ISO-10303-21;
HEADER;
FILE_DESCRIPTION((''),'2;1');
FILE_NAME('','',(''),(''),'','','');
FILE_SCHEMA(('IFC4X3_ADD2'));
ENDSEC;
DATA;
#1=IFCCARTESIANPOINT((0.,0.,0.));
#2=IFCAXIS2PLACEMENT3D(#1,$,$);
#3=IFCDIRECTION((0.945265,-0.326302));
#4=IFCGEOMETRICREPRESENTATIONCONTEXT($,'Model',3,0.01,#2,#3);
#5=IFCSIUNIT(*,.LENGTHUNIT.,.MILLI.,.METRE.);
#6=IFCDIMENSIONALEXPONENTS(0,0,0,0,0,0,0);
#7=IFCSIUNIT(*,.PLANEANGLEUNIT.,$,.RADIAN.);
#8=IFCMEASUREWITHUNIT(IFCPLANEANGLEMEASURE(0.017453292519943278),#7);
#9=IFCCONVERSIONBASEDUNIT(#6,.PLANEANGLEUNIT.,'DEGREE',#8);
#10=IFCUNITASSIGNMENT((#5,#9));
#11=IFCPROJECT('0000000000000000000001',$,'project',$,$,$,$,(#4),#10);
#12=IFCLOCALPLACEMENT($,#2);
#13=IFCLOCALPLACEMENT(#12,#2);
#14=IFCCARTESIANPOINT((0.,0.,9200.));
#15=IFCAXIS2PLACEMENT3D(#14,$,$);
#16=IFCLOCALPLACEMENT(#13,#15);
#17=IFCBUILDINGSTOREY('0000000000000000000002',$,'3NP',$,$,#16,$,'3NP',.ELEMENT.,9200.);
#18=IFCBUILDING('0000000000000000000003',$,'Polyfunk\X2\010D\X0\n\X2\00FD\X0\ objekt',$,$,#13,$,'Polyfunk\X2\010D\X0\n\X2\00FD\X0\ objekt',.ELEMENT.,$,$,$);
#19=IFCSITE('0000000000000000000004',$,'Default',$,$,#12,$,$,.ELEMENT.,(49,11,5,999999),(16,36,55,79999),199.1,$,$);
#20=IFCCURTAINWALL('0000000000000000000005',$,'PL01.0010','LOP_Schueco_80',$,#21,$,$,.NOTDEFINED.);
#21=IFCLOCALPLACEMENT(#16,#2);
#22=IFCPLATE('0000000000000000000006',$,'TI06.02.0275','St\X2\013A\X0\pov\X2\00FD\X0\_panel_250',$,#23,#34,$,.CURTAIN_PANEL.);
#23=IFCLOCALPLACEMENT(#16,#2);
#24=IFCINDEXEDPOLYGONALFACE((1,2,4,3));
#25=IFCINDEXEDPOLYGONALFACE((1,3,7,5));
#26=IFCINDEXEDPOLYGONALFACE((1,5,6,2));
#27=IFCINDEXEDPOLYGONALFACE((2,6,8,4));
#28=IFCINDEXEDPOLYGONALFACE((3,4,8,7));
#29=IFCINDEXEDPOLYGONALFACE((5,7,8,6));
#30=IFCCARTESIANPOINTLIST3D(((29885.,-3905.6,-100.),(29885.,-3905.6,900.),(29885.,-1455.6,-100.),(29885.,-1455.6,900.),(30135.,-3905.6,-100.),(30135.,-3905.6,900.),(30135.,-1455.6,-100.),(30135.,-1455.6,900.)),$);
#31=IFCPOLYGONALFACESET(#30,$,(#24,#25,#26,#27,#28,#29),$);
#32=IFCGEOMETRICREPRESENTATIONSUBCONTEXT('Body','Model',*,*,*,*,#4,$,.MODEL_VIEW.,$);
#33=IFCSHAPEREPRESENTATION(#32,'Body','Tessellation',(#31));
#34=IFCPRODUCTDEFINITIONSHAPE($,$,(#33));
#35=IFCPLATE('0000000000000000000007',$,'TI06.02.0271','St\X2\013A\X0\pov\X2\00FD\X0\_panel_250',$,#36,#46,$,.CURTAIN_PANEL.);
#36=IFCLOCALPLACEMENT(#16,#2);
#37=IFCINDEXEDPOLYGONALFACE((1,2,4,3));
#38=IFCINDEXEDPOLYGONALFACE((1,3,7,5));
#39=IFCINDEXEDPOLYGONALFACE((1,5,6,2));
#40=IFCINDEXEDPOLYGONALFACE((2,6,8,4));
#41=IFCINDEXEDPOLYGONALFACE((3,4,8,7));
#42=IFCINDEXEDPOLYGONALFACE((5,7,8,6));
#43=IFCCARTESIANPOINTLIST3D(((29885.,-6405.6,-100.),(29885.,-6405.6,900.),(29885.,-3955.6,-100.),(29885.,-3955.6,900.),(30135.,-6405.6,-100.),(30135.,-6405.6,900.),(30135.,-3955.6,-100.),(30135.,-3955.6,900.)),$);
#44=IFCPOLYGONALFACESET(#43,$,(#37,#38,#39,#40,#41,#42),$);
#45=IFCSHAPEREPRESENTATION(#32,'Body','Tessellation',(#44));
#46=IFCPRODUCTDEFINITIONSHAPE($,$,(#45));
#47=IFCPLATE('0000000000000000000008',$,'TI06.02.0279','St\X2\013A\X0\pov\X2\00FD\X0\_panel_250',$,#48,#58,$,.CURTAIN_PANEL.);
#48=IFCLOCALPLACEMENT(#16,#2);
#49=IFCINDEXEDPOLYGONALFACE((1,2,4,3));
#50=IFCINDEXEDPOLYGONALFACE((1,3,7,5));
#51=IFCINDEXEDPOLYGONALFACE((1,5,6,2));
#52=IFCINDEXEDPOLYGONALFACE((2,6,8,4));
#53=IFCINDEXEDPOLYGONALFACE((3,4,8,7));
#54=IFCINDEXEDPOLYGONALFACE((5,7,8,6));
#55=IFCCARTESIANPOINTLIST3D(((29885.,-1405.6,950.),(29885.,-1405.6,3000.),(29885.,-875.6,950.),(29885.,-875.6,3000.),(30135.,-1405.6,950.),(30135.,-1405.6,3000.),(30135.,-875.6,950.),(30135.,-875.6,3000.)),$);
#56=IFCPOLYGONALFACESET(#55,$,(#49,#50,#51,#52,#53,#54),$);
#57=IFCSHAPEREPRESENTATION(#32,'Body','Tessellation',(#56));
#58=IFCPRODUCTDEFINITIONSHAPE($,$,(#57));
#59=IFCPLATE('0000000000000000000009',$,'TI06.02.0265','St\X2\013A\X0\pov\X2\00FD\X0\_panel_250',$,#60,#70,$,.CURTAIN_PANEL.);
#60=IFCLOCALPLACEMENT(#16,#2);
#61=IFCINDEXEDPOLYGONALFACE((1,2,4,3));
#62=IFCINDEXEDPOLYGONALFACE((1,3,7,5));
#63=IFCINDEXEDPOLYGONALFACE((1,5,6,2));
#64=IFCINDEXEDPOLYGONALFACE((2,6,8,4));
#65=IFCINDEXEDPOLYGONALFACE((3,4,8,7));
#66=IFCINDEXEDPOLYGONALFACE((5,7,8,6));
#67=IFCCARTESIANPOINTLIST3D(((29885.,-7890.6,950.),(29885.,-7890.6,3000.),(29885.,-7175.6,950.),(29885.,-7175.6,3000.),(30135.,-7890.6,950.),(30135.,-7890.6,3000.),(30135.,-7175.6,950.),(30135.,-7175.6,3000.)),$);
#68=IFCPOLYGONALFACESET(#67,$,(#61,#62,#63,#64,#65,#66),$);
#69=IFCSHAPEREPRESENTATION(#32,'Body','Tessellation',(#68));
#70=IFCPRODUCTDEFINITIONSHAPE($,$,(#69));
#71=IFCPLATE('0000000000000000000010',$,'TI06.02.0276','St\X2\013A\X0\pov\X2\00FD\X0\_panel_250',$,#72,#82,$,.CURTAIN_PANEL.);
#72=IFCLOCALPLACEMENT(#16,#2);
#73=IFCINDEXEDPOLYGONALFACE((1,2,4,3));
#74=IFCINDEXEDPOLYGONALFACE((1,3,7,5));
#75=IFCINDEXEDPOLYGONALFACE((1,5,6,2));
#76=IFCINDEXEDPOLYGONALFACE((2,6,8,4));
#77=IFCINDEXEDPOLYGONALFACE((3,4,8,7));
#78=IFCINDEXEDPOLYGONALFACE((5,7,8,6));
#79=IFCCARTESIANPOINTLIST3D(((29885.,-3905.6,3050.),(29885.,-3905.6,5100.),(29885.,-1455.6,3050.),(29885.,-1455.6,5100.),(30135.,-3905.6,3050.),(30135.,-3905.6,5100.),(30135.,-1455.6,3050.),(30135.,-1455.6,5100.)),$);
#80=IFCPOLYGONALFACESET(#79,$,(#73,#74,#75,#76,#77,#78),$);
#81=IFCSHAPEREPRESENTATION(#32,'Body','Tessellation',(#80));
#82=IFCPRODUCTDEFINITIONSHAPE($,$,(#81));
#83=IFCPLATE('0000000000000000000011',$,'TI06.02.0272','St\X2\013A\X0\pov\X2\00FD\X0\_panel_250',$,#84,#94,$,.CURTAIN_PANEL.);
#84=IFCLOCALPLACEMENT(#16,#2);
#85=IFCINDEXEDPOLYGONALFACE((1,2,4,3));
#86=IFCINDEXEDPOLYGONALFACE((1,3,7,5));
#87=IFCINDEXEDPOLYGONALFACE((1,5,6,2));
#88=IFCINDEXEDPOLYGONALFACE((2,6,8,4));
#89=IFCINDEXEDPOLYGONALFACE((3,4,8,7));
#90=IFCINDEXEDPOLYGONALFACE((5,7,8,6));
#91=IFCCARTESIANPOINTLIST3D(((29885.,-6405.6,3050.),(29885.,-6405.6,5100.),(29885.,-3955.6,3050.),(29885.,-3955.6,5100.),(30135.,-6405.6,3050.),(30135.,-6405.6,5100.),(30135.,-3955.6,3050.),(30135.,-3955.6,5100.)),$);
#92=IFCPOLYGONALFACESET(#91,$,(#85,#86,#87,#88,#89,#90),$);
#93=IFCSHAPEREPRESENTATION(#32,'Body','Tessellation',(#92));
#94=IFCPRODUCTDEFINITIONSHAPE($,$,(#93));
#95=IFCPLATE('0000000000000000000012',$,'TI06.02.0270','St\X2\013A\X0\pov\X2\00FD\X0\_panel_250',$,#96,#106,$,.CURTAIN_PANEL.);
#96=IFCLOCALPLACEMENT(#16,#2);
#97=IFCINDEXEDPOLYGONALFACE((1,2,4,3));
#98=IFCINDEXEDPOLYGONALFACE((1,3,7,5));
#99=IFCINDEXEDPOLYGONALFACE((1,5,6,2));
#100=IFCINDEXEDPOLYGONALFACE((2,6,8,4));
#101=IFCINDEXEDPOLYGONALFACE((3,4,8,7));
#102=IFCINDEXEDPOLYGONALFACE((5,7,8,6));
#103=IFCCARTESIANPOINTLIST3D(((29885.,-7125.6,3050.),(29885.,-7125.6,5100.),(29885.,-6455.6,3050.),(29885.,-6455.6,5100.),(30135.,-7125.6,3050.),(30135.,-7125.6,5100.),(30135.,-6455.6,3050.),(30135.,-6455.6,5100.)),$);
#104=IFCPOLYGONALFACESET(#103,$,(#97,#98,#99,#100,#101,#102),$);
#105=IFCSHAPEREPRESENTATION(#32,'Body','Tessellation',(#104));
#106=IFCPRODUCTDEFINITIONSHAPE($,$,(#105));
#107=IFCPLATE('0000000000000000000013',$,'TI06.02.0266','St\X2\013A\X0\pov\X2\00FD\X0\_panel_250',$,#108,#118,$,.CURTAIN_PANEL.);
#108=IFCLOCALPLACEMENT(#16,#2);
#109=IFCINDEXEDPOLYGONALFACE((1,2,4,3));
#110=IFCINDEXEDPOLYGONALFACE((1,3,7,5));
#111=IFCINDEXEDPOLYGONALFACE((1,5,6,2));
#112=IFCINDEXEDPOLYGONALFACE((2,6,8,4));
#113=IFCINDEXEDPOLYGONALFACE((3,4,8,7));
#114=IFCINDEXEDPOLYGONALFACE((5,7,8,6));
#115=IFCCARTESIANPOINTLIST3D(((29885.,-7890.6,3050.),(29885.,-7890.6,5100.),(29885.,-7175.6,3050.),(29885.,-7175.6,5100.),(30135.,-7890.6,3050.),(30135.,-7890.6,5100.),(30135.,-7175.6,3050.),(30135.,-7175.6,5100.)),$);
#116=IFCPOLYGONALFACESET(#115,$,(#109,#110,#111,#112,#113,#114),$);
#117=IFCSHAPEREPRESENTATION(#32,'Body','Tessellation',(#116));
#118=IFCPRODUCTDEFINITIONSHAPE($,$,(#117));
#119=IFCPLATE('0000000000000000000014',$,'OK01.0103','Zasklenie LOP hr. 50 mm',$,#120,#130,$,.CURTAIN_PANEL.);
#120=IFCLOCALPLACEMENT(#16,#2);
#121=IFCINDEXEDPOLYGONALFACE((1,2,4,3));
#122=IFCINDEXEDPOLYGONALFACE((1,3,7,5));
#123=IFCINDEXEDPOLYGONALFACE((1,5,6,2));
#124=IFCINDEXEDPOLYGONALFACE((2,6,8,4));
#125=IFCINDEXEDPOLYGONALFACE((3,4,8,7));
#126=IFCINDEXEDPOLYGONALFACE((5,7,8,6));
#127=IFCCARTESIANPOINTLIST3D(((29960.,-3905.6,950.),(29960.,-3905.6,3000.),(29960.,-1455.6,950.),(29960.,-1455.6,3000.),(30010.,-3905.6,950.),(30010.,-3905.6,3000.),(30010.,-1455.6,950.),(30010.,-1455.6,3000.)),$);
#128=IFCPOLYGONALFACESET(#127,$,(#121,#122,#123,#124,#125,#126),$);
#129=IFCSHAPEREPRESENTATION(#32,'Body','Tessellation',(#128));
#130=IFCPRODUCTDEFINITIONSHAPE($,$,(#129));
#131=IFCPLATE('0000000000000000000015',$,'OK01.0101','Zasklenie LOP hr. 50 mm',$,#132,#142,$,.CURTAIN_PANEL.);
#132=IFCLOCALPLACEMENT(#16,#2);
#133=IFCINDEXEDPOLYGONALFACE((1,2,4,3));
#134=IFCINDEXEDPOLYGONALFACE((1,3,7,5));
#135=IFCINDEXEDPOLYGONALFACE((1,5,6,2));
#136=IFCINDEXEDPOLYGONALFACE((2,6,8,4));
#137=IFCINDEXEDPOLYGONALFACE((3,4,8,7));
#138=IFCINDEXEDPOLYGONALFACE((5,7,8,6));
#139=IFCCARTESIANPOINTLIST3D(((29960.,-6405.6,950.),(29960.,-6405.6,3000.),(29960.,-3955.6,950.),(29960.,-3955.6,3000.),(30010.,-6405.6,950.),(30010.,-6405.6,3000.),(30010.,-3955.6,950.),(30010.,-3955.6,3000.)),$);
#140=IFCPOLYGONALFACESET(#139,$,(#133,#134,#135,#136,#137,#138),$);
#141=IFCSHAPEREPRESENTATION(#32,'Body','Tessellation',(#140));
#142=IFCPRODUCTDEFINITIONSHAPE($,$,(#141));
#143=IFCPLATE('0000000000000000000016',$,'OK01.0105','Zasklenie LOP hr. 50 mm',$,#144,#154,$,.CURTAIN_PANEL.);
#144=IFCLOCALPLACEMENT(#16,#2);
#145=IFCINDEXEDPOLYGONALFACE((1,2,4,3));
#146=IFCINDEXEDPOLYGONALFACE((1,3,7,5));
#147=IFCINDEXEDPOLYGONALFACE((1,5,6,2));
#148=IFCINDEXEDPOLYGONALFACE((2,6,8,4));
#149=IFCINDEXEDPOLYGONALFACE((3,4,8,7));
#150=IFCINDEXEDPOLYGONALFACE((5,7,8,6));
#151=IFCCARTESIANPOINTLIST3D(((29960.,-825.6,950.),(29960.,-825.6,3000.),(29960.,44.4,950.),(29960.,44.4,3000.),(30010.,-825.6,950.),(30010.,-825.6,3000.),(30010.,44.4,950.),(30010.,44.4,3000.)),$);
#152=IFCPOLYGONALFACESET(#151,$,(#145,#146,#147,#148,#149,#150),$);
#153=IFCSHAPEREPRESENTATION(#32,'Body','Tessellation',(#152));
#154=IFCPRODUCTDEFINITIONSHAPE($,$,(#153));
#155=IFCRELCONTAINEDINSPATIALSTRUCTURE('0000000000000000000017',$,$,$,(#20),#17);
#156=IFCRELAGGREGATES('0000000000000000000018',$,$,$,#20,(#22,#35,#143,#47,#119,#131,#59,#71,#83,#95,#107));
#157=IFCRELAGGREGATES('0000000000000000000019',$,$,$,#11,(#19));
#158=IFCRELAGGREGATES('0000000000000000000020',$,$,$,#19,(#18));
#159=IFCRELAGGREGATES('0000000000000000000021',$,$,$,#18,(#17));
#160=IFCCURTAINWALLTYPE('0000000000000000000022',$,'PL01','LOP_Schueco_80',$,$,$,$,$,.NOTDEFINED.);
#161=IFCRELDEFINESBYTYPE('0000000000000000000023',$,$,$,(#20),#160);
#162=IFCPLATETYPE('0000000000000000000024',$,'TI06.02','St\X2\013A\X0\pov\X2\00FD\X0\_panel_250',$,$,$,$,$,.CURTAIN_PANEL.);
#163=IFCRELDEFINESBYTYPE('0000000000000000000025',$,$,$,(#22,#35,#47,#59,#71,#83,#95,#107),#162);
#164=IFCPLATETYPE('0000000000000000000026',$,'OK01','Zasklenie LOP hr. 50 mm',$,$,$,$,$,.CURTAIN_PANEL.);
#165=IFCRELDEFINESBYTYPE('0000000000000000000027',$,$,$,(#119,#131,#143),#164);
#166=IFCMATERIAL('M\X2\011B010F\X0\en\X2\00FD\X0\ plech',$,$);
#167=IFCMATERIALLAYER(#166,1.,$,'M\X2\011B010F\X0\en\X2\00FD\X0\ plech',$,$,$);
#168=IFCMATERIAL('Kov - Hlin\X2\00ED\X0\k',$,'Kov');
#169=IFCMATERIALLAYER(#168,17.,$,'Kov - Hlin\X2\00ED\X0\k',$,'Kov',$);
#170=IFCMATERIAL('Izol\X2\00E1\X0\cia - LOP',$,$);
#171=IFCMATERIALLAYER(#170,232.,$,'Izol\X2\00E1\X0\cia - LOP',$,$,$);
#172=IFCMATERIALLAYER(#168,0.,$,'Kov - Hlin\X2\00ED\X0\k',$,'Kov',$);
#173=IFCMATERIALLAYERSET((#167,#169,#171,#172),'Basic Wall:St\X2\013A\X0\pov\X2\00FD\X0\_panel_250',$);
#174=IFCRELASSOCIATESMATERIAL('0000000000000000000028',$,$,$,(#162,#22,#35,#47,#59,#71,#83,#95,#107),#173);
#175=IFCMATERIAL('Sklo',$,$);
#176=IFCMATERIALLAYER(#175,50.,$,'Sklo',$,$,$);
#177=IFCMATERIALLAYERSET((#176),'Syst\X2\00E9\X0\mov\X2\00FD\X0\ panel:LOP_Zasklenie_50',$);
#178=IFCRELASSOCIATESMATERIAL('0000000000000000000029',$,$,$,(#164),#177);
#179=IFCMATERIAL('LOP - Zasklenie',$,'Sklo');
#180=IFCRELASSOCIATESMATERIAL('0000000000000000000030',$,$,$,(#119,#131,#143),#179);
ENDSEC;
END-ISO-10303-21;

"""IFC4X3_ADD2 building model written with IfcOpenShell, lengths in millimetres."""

from ifc_helpers import new_model, entity, si_unit, converted_unit, direction, frame, frame_2d, origin, origin_2d_with_axis, place, context, subcontext, project, spatial, rectangle, extrude, source, transform, mapped, material, layer, layer_set, layer_usage, type_object, type_shapes, element, aggregate, save


model = new_model("IFC4X3_ADD2")

# Units and contexts
model_context = context("Model", 3, precision=0.01, world=origin(), true_north=direction((0.945265, -0.326302)))
body_context = subcontext(model_context, "Body", "Model", "MODEL_VIEW")
ifc_project = project(units=[si_unit("LENGTHUNIT", "METRE", prefix="MILLI"), converted_unit("PLANEANGLEUNIT", "DEGREE", entity("IfcPlaneAngleMeasure", 0.017453292519943278), si_unit("PLANEANGLEUNIT", "RADIAN"), dimensions=[0, 0, 0, 0, 0, 0, 0])], contexts=[model_context])

# Site, building, storey
site_placement = place(None, origin())
site = spatial("IfcSite", under=ifc_project, at=site_placement, Name="Default", CompositionType="ELEMENT", RefLatitude=(49, 11, 5, 999999), RefLongitude=(16, 36, 55, 79999), RefElevation=199.1)
building_placement = place(site_placement, origin())
building = spatial("IfcBuilding", under=site, at=building_placement, Name="Polyfunkčný objekt", LongName="Polyfunkčný objekt", CompositionType="ELEMENT")
storey_placement = place(building_placement, frame((0.0, 0.0, 9200.0)))
storey = spatial("IfcBuildingStorey", under=building, at=storey_placement, Name="3NP", LongName="3NP", CompositionType="ELEMENT", Elevation=9200.0)

# Curtain wall, plates
curtain_wall_type = type_object("IfcCurtainWallType", Name="PL01", Description="LOP_Schueco_80", PredefinedType="NOTDEFINED")
curtain_wall_placement = place(storey_placement, frame((0.0, 0.0, -9200.0)))
curtain_wall = element("IfcCurtainWall", 1, at=curtain_wall_placement, inside=storey, type_object=curtain_wall_type, Name="PL01.0010", Description="LOP_Schueco_80", PredefinedType="NOTDEFINED")
ifc_material_1 = material(Name="Měďený plech")
ifc_layer_1 = layer(ifc_material_1, 1.0, Name="Měďený plech")
ifc_material_2 = material(Name="Kov - Hliník", Category="Kov")
ifc_layer_2 = layer(ifc_material_2, 17.0, Name="Kov - Hliník", Category="Kov")
ifc_material_3 = material(Name="Izolácia - LOP")
ifc_layer_3 = layer(ifc_material_3, 232.0, Name="Izolácia - LOP")
ifc_layer_4 = layer(ifc_material_2, 0.0, Name="Kov - Hliník", Category="Kov")
ifc_layer_set_1 = layer_set([ifc_layer_1, ifc_layer_2, ifc_layer_3, ifc_layer_4], Name="Basic Wall:Stĺpový_panel_250")
ifc_layer_usage_1 = layer_usage(ifc_layer_set_1, "AXIS2", "POSITIVE", -125.0)
plate_type_1 = type_object("IfcPlateType", Name="TI06.02", Description="Stĺpový_panel_250", PredefinedType="CURTAIN_PANEL", material=ifc_layer_set_1)
plate_1_placement = place(storey_placement, frame((30010.0, -1455.6, -100.0), z_axis=(0.0, 0.0, 1.0), x_axis=(0.0, -1.0, 0.0)))
plate_1 = element("IfcPlate", 2, at=plate_1_placement, type_object=plate_type_1, material=ifc_layer_usage_1, Name="TI06.02.0275", Description="Stĺpový_panel_250", PredefinedType="CURTAIN_PANEL", context=body_context, shape_type="SweptSolid", body=[
    extrude(rectangle(XDim=250.0, YDim=2450.0, at=origin_2d_with_axis()), frame((1225.0, 0.0, 0.0), z_axis=(0.0, 0.0, 1.0), x_axis=(0.0, 1.0, 0.0)), (0.0, 0.0, 1.0), 1000.0),
])
ifc_layer_usage_2 = layer_usage(ifc_layer_set_1, "AXIS2", "POSITIVE", -125.0)
plate_2_placement = place(storey_placement, frame((30010.0, -3955.6, -100.0), z_axis=(0.0, 0.0, 1.0), x_axis=(0.0, -1.0, 0.0)))
plate_2 = element("IfcPlate", 3, at=plate_2_placement, type_object=plate_type_1, material=ifc_layer_usage_2, Name="TI06.02.0271", Description="Stĺpový_panel_250", PredefinedType="CURTAIN_PANEL", context=body_context, shape_type="SweptSolid", body=[
    extrude(rectangle(XDim=250.0, YDim=2450.0, at=frame_2d((0.0, 0.0), x_axis=(1.0, 0.0))), frame((1225.0, 0.0, 0.0), z_axis=(0.0, 0.0, 1.0), x_axis=(0.0, 1.0, 0.0)), (0.0, 0.0, 1.0), 1000.0),
])
ifc_layer_usage_3 = layer_usage(ifc_layer_set_1, "AXIS2", "POSITIVE", -125.0)
plate_3_placement = place(storey_placement, frame((30010.0, -875.6, 950.0), z_axis=(0.0, 0.0, 1.0), x_axis=(0.0, -1.0, 0.0)))
plate_3 = element("IfcPlate", 4, at=plate_3_placement, type_object=plate_type_1, material=ifc_layer_usage_3, Name="TI06.02.0279", Description="Stĺpový_panel_250", PredefinedType="CURTAIN_PANEL", context=body_context, shape_type="SweptSolid", body=[
    extrude(rectangle(XDim=250.0, YDim=530.0, at=frame_2d((0.0, 0.0), x_axis=(1.0, 0.0))), frame((265.0, 0.0, 0.0), z_axis=(0.0, 0.0, 1.0), x_axis=(0.0, 1.0, 0.0)), (0.0, 0.0, 1.0), 2050.0),
])
ifc_layer_usage_4 = layer_usage(ifc_layer_set_1, "AXIS2", "POSITIVE", -125.0)
plate_4_placement = place(storey_placement, frame((30010.0, -7175.6, 950.0), z_axis=(0.0, 0.0, 1.0), x_axis=(0.0, -1.0, 0.0)))
plate_4 = element("IfcPlate", 5, at=plate_4_placement, type_object=plate_type_1, material=ifc_layer_usage_4, Name="TI06.02.0265", Description="Stĺpový_panel_250", PredefinedType="CURTAIN_PANEL", context=body_context, shape_type="SweptSolid", body=[
    extrude(rectangle(XDim=250.0, YDim=715.0, at=frame_2d((0.0, 0.0), x_axis=(1.0, 0.0))), frame((357.5, 0.0, 0.0), z_axis=(0.0, 0.0, 1.0), x_axis=(0.0, 1.0, 0.0)), (0.0, 0.0, 1.0), 2050.0),
])
ifc_layer_usage_5 = layer_usage(ifc_layer_set_1, "AXIS2", "POSITIVE", -125.0)
plate_5_placement = place(storey_placement, frame((30010.0, -1455.6, 3050.0), z_axis=(0.0, 0.0, 1.0), x_axis=(0.0, -1.0, 0.0)))
plate_5 = element("IfcPlate", 6, at=plate_5_placement, type_object=plate_type_1, material=ifc_layer_usage_5, Name="TI06.02.0276", Description="Stĺpový_panel_250", PredefinedType="CURTAIN_PANEL", context=body_context, shape_type="SweptSolid", body=[
    extrude(rectangle(XDim=250.0, YDim=2450.0, at=origin_2d_with_axis()), frame((1225.0, 0.0, 0.0), z_axis=(0.0, 0.0, 1.0), x_axis=(0.0, 1.0, 0.0)), (0.0, 0.0, 1.0), 2050.0),
])
ifc_layer_usage_6 = layer_usage(ifc_layer_set_1, "AXIS2", "POSITIVE", -125.0)
plate_6_placement = place(storey_placement, frame((30010.0, -3955.6, 3050.0), z_axis=(0.0, 0.0, 1.0), x_axis=(0.0, -1.0, 0.0)))
plate_6 = element("IfcPlate", 7, at=plate_6_placement, type_object=plate_type_1, material=ifc_layer_usage_6, Name="TI06.02.0272", Description="Stĺpový_panel_250", PredefinedType="CURTAIN_PANEL", context=body_context, shape_type="SweptSolid", body=[
    extrude(rectangle(XDim=250.0, YDim=2450.0, at=frame_2d((0.0, 0.0), x_axis=(1.0, 0.0))), frame((1225.0, 0.0, 0.0), z_axis=(0.0, 0.0, 1.0), x_axis=(0.0, 1.0, 0.0)), (0.0, 0.0, 1.0), 2050.0),
])
ifc_layer_usage_7 = layer_usage(ifc_layer_set_1, "AXIS2", "POSITIVE", -125.0)
plate_7_placement = place(storey_placement, frame((30010.0, -6455.6, 3050.0), z_axis=(0.0, 0.0, 1.0), x_axis=(0.0, -1.0, 0.0)))
plate_7 = element("IfcPlate", 8, at=plate_7_placement, type_object=plate_type_1, material=ifc_layer_usage_7, Name="TI06.02.0270", Description="Stĺpový_panel_250", PredefinedType="CURTAIN_PANEL", context=body_context, shape_type="SweptSolid", body=[
    extrude(rectangle(XDim=250.0, YDim=670.0, at=frame_2d((0.0, 0.0), x_axis=(1.0, 0.0))), frame((335.0, 0.0, 0.0), z_axis=(0.0, 0.0, 1.0), x_axis=(0.0, 1.0, 0.0)), (0.0, 0.0, 1.0), 2050.0),
])
ifc_layer_usage_8 = layer_usage(ifc_layer_set_1, "AXIS2", "POSITIVE", -125.0)
plate_8_placement = place(storey_placement, frame((30010.0, -7175.6, 3050.0), z_axis=(0.0, 0.0, 1.0), x_axis=(0.0, -1.0, 0.0)))
plate_8 = element("IfcPlate", 9, at=plate_8_placement, type_object=plate_type_1, material=ifc_layer_usage_8, Name="TI06.02.0266", Description="Stĺpový_panel_250", PredefinedType="CURTAIN_PANEL", context=body_context, shape_type="SweptSolid", body=[
    extrude(rectangle(XDim=250.0, YDim=715.0, at=frame_2d((0.0, 0.0), x_axis=(1.0, 0.0))), frame((357.5, 0.0, 0.0), z_axis=(0.0, 0.0, 1.0), x_axis=(0.0, 1.0, 0.0)), (0.0, 0.0, 1.0), 2050.0),
])
ifc_material_4 = material(Name="LOP - Zasklenie", Category="Sklo")
ifc_material_5 = material(Name="Sklo")
ifc_layer_5 = layer(ifc_material_5, 50.0, Name="Sklo")
ifc_layer_set_2 = layer_set([ifc_layer_5], Name="Systémový panel:LOP_Zasklenie_50")
plate_type_2 = type_object("IfcPlateType", Name="OK01", Description="Zasklenie LOP hr. 50 mm", PredefinedType="CURTAIN_PANEL", material=ifc_layer_set_2)
shared_shape_1 = source(origin(), body_context, "Body", "SweptSolid", [
    extrude(rectangle(XDim=50.0, YDim=2450.0, at=origin_2d_with_axis()), frame((0.0, -25.0, 0.0), z_axis=(0.0, 0.0, 1.0), x_axis=(0.0, 1.0, 0.0)), (0.0, 0.0, 1.0), 2050.0),
])
plate_9_placement = place(curtain_wall_placement, frame((30010.0, -2680.6, 10150.0), z_axis=(0.0, 0.0, 1.0), x_axis=(0.0, -1.0, 0.0)))
plate_9 = element("IfcPlate", 10, at=plate_9_placement, type_object=plate_type_2, material=ifc_material_4, Name="OK01.0103", Description="Zasklenie LOP hr. 50 mm", PredefinedType="CURTAIN_PANEL", context=body_context, shape_type="MappedRepresentation", body=[
    mapped(shared_shape_1, transform((0.0, 0.0, 0.0), scale=1.0)),
])
plate_10_placement = place(curtain_wall_placement, frame((30010.0, -5180.6, 10150.0), z_axis=(0.0, 0.0, 1.0), x_axis=(0.0, -1.0, 0.0)))
plate_10 = element("IfcPlate", 11, at=plate_10_placement, type_object=plate_type_2, material=ifc_material_4, Name="OK01.0101", Description="Zasklenie LOP hr. 50 mm", PredefinedType="CURTAIN_PANEL", context=body_context, shape_type="MappedRepresentation", body=[
    mapped(shared_shape_1, transform((0.0, 0.0, 0.0), scale=1.0)),
])
shared_shape_2 = source(origin(), body_context, "Body", "SweptSolid", [
    extrude(rectangle(XDim=50.0, YDim=870.0, at=origin_2d_with_axis()), frame((0.0, -25.0, 0.0), z_axis=(0.0, 0.0, 1.0), x_axis=(0.0, 1.0, 0.0)), (0.0, 0.0, 1.0), 2050.0),
])
type_shapes(plate_type_2, [shared_shape_1, shared_shape_2])
plate_11_placement = place(curtain_wall_placement, frame((30010.0, -390.6, 10150.0), z_axis=(0.0, 0.0, 1.0), x_axis=(0.0, -1.0, 0.0)))
plate_11 = element("IfcPlate", 12, at=plate_11_placement, type_object=plate_type_2, material=ifc_material_4, Name="OK01.0105", Description="Zasklenie LOP hr. 50 mm", PredefinedType="CURTAIN_PANEL", context=body_context, shape_type="MappedRepresentation", body=[
    mapped(shared_shape_2, transform((0.0, 0.0, 0.0), scale=1.0)),
])
aggregate(curtain_wall, [plate_1, plate_2, plate_11, plate_3, plate_9, plate_10, plate_4, plate_5, plate_6, plate_7, plate_8])

save(model, "model.ifc")
